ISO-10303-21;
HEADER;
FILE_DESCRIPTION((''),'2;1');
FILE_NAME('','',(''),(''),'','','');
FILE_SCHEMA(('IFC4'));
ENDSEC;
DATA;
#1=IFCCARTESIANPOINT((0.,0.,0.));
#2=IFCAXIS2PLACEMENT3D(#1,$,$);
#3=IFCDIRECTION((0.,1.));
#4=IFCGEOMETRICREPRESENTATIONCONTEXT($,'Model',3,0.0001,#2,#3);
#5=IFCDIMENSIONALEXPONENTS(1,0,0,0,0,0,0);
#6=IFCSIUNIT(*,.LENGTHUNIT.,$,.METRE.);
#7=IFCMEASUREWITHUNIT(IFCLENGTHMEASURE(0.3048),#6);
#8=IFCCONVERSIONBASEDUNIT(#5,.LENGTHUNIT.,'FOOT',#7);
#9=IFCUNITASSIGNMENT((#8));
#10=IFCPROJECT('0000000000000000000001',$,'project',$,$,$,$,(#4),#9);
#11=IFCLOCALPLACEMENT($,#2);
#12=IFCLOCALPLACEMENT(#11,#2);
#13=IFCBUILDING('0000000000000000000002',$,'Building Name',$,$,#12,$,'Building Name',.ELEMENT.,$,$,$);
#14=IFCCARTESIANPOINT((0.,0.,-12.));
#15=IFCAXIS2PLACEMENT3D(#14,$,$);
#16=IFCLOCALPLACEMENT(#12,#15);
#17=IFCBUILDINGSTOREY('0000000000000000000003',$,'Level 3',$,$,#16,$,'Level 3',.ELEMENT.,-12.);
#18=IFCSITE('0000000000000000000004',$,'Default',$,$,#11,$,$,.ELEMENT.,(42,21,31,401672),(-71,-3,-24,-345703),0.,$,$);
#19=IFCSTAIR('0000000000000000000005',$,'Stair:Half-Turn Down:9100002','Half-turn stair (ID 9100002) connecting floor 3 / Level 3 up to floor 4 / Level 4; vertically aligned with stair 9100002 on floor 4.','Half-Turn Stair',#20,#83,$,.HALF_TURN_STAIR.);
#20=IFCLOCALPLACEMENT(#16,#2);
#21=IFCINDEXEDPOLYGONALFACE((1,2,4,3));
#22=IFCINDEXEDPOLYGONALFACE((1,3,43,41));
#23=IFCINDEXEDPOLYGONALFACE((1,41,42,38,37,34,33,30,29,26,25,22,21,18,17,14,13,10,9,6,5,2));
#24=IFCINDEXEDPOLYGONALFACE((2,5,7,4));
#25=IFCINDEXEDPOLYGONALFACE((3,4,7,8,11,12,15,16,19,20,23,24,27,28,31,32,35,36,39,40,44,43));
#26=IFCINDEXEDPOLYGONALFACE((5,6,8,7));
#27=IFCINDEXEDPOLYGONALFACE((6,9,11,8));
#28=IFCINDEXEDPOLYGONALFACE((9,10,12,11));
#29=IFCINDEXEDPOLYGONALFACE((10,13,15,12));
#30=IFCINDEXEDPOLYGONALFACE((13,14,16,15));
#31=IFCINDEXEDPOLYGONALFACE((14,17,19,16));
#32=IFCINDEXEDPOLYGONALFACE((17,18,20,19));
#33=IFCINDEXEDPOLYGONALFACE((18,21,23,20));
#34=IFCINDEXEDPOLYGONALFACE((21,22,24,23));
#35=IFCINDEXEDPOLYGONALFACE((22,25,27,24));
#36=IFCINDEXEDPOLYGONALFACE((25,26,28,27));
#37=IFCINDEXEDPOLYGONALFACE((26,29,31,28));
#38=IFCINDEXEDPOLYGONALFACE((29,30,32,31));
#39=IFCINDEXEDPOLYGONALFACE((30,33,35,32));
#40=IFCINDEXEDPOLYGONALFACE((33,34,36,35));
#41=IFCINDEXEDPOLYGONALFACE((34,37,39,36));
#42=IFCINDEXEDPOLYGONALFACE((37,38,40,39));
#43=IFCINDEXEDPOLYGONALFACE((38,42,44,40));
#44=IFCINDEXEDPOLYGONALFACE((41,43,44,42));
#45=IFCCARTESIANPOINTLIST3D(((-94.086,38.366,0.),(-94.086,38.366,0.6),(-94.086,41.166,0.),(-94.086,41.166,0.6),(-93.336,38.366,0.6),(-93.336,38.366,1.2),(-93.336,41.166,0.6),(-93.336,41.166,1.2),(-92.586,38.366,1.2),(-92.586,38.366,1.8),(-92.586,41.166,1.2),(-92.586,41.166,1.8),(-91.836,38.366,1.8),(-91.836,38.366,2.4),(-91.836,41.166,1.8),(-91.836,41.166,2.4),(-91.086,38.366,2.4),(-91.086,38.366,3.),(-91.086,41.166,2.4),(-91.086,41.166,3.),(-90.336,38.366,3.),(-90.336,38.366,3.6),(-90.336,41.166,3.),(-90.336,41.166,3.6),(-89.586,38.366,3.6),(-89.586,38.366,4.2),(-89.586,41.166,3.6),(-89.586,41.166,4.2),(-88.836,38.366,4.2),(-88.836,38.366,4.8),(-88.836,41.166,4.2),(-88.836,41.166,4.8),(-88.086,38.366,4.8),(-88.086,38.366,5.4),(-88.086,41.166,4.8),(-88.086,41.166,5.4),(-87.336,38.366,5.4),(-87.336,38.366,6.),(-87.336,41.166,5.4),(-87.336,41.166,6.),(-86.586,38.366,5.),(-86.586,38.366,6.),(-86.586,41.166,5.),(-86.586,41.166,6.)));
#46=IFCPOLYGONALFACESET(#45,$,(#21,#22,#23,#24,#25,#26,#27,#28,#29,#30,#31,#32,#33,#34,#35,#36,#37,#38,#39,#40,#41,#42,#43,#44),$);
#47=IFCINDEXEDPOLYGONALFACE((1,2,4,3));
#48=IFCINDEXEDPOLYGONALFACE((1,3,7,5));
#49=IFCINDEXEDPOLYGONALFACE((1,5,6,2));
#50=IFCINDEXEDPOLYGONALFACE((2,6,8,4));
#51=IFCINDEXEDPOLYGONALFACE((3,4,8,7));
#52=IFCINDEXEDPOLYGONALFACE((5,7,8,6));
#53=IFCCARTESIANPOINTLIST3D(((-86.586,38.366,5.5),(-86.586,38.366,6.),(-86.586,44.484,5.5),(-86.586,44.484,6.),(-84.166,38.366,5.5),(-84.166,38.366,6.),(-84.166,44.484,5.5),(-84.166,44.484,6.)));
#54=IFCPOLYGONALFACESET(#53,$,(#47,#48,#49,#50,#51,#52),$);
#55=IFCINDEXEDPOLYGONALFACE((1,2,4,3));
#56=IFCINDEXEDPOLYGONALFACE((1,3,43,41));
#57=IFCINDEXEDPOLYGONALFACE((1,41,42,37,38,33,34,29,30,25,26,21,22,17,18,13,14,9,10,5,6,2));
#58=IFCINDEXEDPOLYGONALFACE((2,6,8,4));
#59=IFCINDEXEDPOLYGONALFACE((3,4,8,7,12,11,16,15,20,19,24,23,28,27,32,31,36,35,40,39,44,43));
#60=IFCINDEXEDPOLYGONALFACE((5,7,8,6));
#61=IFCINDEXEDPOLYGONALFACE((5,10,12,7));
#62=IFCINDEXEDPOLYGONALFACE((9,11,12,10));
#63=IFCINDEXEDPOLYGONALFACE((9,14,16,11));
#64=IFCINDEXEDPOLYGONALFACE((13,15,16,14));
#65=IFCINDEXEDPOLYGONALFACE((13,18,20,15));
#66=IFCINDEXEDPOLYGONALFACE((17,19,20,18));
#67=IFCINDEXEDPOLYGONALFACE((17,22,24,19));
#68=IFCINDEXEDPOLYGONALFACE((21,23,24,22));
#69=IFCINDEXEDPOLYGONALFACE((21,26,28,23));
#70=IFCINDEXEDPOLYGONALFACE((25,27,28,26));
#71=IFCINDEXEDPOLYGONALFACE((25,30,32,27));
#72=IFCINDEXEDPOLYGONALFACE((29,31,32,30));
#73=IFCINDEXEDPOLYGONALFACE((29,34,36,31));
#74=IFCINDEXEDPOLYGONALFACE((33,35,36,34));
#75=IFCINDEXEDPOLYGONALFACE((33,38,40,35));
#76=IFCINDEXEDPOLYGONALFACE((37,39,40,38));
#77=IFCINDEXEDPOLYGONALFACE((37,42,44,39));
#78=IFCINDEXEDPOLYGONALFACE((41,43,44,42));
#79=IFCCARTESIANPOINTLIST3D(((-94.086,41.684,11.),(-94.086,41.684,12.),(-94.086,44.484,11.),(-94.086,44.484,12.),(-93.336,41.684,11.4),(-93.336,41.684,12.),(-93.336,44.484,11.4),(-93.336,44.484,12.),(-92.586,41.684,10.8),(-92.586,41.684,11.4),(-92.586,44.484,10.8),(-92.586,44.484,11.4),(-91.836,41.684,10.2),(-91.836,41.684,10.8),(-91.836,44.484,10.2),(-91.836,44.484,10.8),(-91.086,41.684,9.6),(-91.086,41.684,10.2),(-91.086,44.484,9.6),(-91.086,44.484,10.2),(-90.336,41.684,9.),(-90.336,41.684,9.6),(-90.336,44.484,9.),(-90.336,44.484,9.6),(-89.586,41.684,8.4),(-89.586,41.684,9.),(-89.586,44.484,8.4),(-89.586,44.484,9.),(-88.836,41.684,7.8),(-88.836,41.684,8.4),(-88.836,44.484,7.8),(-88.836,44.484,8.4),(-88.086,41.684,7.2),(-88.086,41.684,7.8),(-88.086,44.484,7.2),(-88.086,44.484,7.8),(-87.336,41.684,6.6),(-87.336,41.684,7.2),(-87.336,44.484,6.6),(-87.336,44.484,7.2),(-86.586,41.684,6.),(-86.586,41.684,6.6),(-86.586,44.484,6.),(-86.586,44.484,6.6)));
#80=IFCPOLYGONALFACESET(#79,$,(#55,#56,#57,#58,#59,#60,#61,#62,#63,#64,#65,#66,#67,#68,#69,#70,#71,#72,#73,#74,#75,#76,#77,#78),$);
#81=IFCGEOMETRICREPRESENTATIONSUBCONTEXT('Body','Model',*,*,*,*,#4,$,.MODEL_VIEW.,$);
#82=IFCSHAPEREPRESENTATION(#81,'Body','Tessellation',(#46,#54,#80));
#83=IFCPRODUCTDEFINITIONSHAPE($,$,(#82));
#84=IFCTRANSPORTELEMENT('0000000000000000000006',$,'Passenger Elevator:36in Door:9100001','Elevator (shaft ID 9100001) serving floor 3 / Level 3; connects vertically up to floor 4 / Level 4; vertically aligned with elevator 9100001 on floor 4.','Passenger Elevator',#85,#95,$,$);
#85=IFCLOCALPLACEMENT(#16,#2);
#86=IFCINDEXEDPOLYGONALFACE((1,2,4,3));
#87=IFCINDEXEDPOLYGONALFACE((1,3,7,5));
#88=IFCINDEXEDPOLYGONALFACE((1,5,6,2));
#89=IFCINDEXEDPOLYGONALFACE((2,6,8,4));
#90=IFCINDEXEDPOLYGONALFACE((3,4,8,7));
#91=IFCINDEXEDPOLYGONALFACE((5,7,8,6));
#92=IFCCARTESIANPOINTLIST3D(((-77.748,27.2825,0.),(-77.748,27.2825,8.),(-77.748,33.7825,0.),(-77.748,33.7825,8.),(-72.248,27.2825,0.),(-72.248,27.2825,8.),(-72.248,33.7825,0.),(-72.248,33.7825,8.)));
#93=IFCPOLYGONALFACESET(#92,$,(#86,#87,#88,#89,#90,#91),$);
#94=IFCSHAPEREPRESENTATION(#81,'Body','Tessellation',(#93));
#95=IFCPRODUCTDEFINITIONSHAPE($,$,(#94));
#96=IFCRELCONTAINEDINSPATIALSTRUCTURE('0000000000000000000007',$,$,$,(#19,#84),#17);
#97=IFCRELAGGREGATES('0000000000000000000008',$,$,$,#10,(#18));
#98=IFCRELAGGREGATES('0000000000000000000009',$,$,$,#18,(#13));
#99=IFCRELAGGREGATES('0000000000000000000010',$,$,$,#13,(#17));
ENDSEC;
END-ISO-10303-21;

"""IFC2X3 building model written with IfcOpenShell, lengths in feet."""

from ifc_helpers import new_model, entity, si_unit, converted_unit, direction, frame, frame_2d, origin, place, context, subcontext, project, spatial, polyline, rectangle, outline, extrude, element, save


model = new_model("IFC2X3")

# Units and contexts
model_context = context("Model", 3, precision=0.0001, world=origin(), true_north=direction((0.0, 1.0)))
body_context = subcontext(model_context, "Body", "Model", "MODEL_VIEW")
ifc_project = project(units=[converted_unit("LENGTHUNIT", "FOOT", entity("IfcLengthMeasure", 0.3048), si_unit("LENGTHUNIT", "METRE"), dimensions=[1, 0, 0, 0, 0, 0, 0])], contexts=[model_context])

# Site, building, storey
site_placement = place(None, origin())
site = spatial("IfcSite", under=ifc_project, at=site_placement, Name="Default", CompositionType="ELEMENT", RefLatitude=(42, 21, 31, 401672), RefLongitude=(-71, -3, -24, -345703), RefElevation=0.0)
building_placement = place(site_placement, origin())
building = spatial("IfcBuilding", under=site, at=building_placement, Name="Building Name", LongName="Building Name", CompositionType="ELEMENT")
storey_placement = place(building_placement, frame((0.0, 0.0, -12.0)))
storey = spatial("IfcBuildingStorey", under=building, at=storey_placement, Name="Level 3", LongName="Level 3", CompositionType="ELEMENT", Elevation=-12.0)

# Stair
stair_placement = place(storey_placement, frame((-94.086, 38.366, 0.0), z_axis=(0.0, 0.0, 1.0), x_axis=(1.0, 0.0, 0.0)))
element("IfcStair", 1, at=stair_placement, inside=storey, Name="Stair:Half-Turn Down:9100002", Description="Half-turn stair (ID 9100002) connecting floor 3 / Level 3 up to floor 4 / Level 4; vertically aligned with stair 9100002 on floor 4.", ObjectType="Half-Turn Stair", ShapeType="HALF_TURN_STAIR", context=body_context, shape_type="SweptSolid", body=[
    extrude(outline(polyline([(0.0, 0.0), (0.0, 0.6), (0.75, 0.6), (0.75, 1.2), (1.5, 1.2), (1.5, 1.8), (2.25, 1.8), (2.25, 2.4), (3.0, 2.4), (3.0, 3.0), (3.75, 3.0), (3.75, 3.6), (4.5, 3.6), (4.5, 4.2), (5.25, 4.2), (5.25, 4.8), (6.0, 4.8), (6.0, 5.4), (6.75, 5.4), (6.75, 6.0), (7.5, 6.0), (7.5, 5.0), (0.0, 0.0)])), frame((0.0, 2.8, 0.0), z_axis=(0.0, -1.0, 0.0), x_axis=(1.0, 0.0, 0.0)), (0.0, 0.0, 1.0), 2.8),
    extrude(rectangle(XDim=2.42, YDim=6.118, at=frame_2d((8.71, 3.059))), frame((0.0, 0.0, 5.5)), (0.0, 0.0, 1.0), 0.5),
    extrude(outline(polyline([(0.0, 0.0), (0.0, 0.6), (0.75, 0.6), (0.75, 1.2), (1.5, 1.2), (1.5, 1.8), (2.25, 1.8), (2.25, 2.4), (3.0, 2.4), (3.0, 3.0), (3.75, 3.0), (3.75, 3.6), (4.5, 3.6), (4.5, 4.2), (5.25, 4.2), (5.25, 4.8), (6.0, 4.8), (6.0, 5.4), (6.75, 5.4), (6.75, 6.0), (7.5, 6.0), (7.5, 5.0), (0.0, 0.0)])), frame((7.5, 3.318, 6.0), z_axis=(0.0, 1.0, 0.0), x_axis=(-1.0, 0.0, 0.0)), (0.0, 0.0, 1.0), 2.8),
])

# Transport element
transport_element_placement = place(storey_placement, frame((-77.748, 30.5325, 0.0), z_axis=(0.0, 0.0, 1.0), x_axis=(1.0, 0.0, 0.0)))
element("IfcTransportElement", 2, at=transport_element_placement, inside=storey, Name="Passenger Elevator:36in Door:9100001", Description="Elevator (shaft ID 9100001) serving floor 3 / Level 3; connects vertically up to floor 4 / Level 4; vertically aligned with elevator 9100001 on floor 4.", ObjectType="Passenger Elevator", OperationType="ELEVATOR", context=body_context, shape_type="SweptSolid", body=[
    extrude(rectangle(XDim=5.5, YDim=6.5, at=frame_2d((2.75, 0.0))), origin(), (0.0, 0.0, 1.0), 8.0),
])

save(model, "model.ifc")
